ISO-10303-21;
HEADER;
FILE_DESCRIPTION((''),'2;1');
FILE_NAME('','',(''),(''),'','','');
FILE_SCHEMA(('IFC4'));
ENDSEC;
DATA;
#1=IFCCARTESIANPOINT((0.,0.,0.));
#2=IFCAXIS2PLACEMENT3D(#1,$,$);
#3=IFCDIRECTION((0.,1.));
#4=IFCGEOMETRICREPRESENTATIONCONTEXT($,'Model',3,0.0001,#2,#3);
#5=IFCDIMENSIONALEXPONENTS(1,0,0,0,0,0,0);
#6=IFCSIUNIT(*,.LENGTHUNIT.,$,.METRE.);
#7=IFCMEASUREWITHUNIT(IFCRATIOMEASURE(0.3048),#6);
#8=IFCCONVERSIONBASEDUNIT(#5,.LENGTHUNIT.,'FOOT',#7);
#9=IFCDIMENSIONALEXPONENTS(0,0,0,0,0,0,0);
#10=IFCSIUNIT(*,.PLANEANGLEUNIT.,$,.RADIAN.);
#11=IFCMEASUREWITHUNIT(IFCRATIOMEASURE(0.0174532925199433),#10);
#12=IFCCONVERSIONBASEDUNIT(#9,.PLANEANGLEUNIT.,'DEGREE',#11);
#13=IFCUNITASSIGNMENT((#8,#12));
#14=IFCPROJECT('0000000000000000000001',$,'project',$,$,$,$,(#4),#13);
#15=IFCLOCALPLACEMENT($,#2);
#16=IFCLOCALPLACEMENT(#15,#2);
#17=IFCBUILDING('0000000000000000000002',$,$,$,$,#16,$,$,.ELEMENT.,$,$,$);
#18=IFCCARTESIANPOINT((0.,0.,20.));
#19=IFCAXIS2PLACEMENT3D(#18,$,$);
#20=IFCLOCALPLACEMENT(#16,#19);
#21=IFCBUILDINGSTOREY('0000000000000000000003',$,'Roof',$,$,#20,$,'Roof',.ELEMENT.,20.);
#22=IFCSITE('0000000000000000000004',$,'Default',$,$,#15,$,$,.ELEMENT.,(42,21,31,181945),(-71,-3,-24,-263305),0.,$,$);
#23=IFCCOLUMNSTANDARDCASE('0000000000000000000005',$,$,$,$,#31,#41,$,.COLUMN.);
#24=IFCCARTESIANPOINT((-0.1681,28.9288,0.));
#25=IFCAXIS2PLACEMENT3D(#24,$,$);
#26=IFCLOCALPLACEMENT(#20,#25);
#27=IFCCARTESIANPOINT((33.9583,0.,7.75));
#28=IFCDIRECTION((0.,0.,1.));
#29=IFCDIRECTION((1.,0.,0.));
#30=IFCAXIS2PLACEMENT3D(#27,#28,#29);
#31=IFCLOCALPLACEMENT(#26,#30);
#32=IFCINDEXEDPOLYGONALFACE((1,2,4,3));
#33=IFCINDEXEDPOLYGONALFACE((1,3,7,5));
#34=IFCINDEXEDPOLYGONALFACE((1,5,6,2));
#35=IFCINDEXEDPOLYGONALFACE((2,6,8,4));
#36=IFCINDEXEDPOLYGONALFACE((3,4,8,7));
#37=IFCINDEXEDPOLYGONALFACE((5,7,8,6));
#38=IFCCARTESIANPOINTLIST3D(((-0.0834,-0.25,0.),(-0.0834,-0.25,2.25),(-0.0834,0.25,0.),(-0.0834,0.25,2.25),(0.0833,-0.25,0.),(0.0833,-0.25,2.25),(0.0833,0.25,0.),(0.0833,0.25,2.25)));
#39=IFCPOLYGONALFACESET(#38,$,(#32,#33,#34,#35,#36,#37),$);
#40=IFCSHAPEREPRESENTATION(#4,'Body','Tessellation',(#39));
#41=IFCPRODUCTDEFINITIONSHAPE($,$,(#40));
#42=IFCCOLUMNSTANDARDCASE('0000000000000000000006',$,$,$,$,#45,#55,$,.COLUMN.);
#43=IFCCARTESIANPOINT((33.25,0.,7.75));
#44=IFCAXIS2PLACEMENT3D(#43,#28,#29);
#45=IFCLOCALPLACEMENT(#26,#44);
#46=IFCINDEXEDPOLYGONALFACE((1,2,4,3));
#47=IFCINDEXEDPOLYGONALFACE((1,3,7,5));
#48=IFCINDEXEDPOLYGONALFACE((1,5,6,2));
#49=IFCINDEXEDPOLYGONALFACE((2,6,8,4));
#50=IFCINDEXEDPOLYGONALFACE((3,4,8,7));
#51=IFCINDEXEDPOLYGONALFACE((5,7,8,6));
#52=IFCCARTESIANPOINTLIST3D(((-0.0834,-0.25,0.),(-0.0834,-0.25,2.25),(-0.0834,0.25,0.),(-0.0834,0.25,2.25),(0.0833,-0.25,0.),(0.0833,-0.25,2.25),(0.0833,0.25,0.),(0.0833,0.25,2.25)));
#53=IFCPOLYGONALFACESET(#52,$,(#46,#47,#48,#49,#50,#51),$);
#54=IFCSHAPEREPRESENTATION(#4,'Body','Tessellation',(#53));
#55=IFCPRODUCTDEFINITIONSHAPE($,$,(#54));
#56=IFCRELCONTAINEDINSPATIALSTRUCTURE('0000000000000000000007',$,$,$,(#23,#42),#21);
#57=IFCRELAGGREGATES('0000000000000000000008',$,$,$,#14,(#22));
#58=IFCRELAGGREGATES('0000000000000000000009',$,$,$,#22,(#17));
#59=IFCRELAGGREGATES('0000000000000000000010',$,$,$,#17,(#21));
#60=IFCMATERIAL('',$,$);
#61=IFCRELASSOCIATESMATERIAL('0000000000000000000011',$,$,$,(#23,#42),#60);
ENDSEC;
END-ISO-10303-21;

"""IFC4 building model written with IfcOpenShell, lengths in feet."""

from ifc_helpers import new_model, entity, si_unit, converted_unit, direction, frame, origin, place, context, project, spatial, rectangle, extrude, material, element, save


model = new_model("IFC4")

# Units and contexts
model_context = context("Model", 3, precision=0.0001, world=origin(), true_north=direction((0.0, 1.0)))
ifc_project = project(units=[converted_unit("LENGTHUNIT", "FOOT", entity("IfcRatioMeasure", 0.3048), si_unit("LENGTHUNIT", "METRE"), dimensions=[1, 0, 0, 0, 0, 0, 0]), converted_unit("PLANEANGLEUNIT", "DEGREE", entity("IfcRatioMeasure", 0.0174532925199433), si_unit("PLANEANGLEUNIT", "RADIAN"), dimensions=[0, 0, 0, 0, 0, 0, 0])], contexts=[model_context])

# Site, building, storey
site_placement = place(None, origin())
site = spatial("IfcSite", under=ifc_project, at=site_placement, Name="Default", CompositionType="ELEMENT", RefLatitude=(42, 21, 31, 181945), RefLongitude=(-71, -3, -24, -263305), RefElevation=0.0)
building_placement = place(site_placement, origin())
building = spatial("IfcBuilding", under=site, at=building_placement, CompositionType="ELEMENT")
storey_placement = place(building_placement, frame((0.0, 0.0, 20.0)))
storey = spatial("IfcBuildingStorey", under=building, at=storey_placement, Name="Roof", LongName="Roof", CompositionType="ELEMENT", Elevation=20.0)

# Columns
ifc_material_1 = material(Name="")
placement = place(storey_placement, frame((-0.1681, 28.9288, 0.0)))
for number, where, z_axis, x_axis in (
    (1, (33.9583, 0.0, 7.75), (0.0, 0.0, 1.0), (1.0, 0.0, 0.0)),
    (2, (33.25, 0.0, 7.75), (0.0, 0.0, 1.0), (1.0, 0.0, 0.0)),
):
    element("IfcColumnStandardCase", number, at=place(placement, frame(where, z_axis=z_axis, x_axis=x_axis)), inside=storey, material=ifc_material_1, PredefinedType="COLUMN", context=model_context, shape_type="SweptSolid", body=[
        extrude(rectangle(XDim=0.1667, YDim=0.5), origin(), (0.0, 0.0, 1.0), 2.25),
    ])

save(model, "model.ifc")
